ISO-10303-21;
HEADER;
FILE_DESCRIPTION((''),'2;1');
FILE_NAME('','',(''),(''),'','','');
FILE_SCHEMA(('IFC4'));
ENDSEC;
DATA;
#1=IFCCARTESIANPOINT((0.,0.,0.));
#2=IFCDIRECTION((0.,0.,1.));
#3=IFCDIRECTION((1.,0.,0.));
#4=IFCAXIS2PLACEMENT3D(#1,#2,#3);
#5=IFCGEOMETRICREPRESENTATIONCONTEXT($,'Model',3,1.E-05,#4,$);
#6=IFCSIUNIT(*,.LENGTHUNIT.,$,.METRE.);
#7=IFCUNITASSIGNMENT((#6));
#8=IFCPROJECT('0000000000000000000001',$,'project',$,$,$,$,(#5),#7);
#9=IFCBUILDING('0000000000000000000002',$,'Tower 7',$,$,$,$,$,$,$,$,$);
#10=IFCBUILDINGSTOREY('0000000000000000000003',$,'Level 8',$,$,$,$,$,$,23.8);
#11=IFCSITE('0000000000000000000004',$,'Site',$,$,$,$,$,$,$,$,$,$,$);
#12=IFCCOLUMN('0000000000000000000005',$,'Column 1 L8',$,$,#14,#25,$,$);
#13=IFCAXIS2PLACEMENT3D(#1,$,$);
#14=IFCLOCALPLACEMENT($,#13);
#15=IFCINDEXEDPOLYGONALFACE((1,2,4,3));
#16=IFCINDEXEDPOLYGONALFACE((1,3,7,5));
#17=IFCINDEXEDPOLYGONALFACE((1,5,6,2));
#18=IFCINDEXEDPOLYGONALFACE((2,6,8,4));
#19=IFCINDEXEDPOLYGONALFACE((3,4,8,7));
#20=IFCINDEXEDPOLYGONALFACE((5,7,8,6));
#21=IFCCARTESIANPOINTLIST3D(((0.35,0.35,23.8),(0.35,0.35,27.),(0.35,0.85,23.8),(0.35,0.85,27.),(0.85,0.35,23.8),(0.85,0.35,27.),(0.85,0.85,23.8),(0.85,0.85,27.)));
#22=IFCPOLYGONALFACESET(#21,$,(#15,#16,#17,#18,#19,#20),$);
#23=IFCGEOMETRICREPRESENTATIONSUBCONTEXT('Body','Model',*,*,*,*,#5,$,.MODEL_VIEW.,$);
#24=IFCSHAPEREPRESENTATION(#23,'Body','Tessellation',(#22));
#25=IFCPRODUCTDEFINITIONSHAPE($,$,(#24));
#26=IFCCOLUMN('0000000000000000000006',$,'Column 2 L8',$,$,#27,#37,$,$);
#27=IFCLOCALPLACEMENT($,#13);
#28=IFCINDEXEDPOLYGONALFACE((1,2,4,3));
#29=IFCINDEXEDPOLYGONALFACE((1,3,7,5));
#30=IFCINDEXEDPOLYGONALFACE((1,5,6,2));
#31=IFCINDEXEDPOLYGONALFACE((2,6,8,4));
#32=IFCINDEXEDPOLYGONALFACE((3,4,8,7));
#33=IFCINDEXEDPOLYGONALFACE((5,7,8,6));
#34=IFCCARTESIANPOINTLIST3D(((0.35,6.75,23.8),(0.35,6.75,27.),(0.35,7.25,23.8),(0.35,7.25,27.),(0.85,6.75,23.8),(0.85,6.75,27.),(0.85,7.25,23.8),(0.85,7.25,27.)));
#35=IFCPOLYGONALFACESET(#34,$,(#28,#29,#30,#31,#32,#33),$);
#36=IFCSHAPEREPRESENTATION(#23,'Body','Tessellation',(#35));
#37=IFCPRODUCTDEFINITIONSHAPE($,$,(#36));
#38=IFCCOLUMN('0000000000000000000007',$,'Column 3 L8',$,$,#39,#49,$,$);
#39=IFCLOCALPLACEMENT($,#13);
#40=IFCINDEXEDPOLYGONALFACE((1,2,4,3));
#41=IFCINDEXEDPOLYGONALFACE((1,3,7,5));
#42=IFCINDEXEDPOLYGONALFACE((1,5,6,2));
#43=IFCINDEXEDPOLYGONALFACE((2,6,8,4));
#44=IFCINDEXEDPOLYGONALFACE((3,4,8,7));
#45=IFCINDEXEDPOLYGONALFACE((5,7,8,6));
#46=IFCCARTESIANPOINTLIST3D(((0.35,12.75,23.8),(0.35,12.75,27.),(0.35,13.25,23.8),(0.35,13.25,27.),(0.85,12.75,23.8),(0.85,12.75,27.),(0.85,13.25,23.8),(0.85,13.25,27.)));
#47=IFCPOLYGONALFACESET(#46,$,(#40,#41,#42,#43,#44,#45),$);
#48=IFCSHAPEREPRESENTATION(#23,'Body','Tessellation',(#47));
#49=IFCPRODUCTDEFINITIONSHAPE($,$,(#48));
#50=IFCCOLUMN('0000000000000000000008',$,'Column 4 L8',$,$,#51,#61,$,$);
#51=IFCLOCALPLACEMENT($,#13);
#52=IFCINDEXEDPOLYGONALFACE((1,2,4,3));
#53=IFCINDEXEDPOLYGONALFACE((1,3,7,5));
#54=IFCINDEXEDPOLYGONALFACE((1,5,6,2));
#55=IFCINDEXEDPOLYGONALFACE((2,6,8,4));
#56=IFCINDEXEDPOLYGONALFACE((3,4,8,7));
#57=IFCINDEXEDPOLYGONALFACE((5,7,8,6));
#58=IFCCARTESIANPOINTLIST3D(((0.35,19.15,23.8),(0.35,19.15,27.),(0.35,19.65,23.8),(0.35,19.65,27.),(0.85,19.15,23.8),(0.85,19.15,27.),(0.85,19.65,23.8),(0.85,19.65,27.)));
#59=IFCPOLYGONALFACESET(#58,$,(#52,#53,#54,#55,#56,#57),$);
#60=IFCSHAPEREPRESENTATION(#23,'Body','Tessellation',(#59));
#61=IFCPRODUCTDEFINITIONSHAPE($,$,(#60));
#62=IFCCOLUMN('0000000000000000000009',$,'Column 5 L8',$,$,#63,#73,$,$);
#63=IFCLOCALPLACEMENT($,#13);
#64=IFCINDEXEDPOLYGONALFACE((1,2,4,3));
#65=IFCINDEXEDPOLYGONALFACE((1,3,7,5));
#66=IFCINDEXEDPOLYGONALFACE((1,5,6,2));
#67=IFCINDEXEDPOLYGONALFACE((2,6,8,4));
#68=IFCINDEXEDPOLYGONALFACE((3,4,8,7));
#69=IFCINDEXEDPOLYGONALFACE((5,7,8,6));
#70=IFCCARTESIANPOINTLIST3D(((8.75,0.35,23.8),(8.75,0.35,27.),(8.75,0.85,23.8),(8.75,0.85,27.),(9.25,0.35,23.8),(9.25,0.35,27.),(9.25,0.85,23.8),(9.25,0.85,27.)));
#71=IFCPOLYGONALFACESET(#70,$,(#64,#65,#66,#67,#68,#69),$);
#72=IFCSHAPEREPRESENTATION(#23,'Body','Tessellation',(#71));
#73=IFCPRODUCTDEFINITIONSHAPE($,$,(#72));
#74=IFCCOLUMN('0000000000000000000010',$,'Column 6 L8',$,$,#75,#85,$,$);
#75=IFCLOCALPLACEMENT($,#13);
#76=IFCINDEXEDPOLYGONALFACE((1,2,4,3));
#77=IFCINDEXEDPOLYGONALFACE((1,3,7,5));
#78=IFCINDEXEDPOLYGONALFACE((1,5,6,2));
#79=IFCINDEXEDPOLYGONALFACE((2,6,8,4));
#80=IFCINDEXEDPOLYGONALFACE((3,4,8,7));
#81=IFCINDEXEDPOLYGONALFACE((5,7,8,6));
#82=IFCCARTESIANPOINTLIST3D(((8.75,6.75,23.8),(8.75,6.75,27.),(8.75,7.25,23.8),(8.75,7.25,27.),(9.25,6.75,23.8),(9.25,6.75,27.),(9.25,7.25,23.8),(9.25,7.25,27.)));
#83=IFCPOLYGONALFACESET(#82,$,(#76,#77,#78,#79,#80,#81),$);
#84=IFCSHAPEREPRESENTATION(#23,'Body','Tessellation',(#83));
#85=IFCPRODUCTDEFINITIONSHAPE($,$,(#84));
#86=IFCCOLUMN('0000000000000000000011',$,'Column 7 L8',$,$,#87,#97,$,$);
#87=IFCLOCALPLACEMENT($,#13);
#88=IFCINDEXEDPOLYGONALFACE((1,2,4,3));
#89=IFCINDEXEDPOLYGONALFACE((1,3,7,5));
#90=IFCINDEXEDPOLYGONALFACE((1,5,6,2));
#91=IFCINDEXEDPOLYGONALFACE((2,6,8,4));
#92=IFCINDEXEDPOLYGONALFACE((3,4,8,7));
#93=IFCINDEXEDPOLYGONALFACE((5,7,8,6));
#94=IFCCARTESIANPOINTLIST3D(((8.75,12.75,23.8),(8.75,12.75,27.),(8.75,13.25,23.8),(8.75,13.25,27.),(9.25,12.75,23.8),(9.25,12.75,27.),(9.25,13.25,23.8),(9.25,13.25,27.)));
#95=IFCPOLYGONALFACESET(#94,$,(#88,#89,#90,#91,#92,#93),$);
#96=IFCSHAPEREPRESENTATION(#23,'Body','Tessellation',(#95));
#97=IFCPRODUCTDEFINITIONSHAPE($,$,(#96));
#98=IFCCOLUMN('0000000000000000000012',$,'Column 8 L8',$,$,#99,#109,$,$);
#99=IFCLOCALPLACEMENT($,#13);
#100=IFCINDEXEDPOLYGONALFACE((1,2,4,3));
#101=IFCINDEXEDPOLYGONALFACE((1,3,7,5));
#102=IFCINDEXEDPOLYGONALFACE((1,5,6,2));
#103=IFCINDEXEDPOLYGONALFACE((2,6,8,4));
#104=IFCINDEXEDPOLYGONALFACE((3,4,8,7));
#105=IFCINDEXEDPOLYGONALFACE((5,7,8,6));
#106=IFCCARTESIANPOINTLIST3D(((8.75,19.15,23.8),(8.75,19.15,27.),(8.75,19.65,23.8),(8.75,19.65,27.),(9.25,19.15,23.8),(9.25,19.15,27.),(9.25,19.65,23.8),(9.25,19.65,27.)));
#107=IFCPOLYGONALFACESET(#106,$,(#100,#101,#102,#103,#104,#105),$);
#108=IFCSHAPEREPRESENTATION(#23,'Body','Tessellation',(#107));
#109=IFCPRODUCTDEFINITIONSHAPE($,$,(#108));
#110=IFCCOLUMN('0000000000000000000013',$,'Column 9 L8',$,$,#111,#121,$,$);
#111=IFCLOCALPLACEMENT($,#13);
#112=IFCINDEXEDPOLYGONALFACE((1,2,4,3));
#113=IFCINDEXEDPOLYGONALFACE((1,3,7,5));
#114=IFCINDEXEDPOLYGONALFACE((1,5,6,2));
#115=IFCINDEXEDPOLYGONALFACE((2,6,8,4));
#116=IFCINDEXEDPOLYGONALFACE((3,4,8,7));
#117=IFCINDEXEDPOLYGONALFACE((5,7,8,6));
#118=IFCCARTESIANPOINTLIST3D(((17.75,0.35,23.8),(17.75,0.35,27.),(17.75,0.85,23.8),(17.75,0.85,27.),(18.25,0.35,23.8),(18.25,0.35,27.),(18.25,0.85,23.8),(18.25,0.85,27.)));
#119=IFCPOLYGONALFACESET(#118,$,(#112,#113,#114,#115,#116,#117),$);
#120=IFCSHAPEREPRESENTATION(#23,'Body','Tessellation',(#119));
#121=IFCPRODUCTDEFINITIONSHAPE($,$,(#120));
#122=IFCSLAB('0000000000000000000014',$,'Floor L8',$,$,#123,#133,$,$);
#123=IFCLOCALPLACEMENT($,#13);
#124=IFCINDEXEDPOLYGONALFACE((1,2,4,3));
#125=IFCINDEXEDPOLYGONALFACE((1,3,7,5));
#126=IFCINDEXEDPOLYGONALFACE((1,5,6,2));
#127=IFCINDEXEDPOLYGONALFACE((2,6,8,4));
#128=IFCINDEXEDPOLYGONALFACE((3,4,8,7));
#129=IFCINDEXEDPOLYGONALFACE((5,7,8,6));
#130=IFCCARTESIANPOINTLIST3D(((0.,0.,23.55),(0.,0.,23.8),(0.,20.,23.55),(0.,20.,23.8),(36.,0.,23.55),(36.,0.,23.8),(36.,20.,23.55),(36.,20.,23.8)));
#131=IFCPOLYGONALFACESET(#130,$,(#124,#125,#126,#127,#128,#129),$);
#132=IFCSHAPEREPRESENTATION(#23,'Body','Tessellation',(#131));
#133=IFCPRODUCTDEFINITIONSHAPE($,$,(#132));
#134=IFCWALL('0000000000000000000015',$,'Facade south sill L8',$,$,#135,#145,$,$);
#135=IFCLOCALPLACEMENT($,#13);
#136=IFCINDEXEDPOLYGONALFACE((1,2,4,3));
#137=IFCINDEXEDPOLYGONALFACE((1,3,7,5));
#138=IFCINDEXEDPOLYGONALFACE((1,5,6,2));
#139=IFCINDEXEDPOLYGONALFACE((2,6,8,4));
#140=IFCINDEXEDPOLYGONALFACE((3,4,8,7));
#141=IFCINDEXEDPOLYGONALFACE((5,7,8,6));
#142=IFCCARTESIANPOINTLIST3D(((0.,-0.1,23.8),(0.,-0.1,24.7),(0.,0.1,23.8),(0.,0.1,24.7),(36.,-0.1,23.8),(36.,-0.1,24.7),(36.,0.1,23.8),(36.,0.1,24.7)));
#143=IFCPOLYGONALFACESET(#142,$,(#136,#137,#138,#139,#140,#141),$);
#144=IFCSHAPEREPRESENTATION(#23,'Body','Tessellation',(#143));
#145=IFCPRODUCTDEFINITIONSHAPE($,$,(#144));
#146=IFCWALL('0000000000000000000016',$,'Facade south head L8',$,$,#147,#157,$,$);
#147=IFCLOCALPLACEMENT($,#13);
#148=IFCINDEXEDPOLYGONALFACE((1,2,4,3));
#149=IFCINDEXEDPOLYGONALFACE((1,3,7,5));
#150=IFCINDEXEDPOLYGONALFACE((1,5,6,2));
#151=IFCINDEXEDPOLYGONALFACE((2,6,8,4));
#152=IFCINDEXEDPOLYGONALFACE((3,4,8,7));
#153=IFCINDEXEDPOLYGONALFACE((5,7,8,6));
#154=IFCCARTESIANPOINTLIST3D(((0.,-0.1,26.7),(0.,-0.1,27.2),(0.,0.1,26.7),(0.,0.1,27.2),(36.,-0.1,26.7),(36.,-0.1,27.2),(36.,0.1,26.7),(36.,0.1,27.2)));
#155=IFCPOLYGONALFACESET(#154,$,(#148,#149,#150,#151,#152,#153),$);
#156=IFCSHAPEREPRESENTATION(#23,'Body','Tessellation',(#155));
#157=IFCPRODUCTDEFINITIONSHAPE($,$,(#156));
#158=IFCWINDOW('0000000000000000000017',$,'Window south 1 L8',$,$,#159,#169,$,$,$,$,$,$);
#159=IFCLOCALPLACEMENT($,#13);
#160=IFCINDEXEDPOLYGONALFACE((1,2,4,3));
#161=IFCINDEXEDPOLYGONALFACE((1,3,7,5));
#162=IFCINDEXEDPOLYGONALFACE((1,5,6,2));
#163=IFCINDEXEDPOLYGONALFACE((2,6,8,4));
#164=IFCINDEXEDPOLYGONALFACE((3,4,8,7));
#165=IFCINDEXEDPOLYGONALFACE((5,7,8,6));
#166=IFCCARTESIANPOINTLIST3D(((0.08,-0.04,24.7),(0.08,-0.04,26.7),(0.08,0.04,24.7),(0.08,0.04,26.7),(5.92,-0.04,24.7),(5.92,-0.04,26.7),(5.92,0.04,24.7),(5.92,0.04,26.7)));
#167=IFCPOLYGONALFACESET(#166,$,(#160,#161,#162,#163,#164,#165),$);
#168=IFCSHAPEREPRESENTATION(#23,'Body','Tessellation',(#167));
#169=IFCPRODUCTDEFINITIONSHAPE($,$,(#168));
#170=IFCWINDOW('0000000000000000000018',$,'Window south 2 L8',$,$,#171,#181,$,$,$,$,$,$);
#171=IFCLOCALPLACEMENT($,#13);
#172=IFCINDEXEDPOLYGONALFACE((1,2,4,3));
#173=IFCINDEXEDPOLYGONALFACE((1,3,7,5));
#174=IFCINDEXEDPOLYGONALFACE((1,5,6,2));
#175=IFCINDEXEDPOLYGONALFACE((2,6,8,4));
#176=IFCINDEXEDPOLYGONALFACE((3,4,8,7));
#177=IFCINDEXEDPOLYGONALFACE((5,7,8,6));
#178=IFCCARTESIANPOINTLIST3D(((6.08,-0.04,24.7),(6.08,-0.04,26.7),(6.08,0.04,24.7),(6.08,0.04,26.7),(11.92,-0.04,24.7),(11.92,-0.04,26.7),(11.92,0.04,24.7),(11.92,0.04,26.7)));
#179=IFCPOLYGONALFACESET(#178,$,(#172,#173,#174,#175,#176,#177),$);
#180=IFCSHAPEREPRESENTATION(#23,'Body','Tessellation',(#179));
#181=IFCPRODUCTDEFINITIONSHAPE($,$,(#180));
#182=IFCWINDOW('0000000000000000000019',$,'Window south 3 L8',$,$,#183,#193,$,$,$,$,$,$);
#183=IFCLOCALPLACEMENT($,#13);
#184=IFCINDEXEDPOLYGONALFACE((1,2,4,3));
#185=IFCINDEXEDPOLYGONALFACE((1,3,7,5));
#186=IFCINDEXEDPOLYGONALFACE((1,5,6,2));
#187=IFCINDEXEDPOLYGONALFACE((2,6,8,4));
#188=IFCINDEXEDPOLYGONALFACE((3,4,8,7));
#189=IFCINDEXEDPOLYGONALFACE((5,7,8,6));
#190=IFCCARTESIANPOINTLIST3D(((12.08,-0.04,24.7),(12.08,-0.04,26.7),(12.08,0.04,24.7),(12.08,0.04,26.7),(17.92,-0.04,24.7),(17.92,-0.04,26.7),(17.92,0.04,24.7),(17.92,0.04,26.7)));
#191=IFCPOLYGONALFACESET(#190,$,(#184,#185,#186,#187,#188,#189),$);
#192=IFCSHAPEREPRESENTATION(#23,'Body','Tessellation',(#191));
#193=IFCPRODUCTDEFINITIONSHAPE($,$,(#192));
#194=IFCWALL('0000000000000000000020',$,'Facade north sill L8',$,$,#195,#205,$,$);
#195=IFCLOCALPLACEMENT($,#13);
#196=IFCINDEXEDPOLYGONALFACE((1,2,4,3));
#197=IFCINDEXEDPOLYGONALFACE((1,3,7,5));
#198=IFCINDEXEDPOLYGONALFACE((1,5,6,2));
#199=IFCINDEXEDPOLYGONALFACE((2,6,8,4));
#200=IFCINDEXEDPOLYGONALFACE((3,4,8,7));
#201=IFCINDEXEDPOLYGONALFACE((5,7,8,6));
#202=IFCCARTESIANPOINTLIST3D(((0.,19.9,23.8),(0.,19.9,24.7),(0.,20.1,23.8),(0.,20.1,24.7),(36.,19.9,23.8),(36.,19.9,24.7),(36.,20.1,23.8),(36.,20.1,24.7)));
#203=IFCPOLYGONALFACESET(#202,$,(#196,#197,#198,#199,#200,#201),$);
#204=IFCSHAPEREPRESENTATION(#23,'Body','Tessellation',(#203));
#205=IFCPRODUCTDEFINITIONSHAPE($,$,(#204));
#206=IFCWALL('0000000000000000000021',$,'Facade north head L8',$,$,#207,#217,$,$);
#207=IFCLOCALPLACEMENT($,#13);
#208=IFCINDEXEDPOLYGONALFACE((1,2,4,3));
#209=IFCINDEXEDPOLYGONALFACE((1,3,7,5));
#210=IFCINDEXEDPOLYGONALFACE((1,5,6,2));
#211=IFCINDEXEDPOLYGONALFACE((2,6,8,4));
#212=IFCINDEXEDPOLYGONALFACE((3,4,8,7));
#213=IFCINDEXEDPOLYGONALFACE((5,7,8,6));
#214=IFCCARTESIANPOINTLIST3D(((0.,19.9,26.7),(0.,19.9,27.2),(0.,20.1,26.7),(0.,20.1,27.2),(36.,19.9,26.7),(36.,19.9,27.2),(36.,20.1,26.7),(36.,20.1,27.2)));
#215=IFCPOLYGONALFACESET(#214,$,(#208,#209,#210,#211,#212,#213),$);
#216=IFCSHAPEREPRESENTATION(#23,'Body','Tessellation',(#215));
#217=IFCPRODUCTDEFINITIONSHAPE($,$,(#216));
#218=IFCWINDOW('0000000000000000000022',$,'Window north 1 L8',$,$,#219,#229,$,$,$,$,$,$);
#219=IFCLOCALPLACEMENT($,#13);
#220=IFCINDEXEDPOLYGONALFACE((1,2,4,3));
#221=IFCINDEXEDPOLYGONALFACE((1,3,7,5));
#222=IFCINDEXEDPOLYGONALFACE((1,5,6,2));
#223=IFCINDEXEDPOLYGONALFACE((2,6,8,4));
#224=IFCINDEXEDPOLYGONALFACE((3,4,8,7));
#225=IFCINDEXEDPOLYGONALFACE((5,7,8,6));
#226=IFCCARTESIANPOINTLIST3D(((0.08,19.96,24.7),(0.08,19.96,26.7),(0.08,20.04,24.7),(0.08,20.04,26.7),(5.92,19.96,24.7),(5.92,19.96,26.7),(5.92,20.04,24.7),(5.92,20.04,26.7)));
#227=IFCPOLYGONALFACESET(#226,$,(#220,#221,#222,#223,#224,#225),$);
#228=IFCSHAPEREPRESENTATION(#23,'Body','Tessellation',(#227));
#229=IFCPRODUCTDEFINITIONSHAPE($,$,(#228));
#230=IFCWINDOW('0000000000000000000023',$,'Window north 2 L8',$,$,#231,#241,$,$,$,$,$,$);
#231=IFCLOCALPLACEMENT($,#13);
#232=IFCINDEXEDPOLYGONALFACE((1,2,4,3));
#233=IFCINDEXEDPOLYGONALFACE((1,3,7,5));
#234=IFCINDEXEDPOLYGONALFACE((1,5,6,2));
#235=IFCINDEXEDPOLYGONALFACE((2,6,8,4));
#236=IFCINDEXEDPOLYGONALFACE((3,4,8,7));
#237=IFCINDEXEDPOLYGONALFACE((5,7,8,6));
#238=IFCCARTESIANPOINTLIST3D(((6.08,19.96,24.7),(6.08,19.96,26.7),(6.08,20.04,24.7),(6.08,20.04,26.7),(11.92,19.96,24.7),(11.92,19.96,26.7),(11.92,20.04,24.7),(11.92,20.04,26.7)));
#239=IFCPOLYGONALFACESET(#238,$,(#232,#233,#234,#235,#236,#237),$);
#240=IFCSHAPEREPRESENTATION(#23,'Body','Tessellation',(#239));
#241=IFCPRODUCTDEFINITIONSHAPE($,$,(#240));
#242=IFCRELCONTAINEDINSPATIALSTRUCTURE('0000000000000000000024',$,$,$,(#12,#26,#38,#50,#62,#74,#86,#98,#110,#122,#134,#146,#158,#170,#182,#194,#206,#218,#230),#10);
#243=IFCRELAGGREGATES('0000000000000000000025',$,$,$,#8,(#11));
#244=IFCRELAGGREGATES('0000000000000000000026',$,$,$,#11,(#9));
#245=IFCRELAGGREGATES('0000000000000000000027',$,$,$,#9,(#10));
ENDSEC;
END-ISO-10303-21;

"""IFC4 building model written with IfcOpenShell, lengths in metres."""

from ifc_helpers import new_model, si_unit, frame, origin, origin_with_axes, origin_2d, place, context, subcontext, project, spatial, rectangle, extrude, element, save


model = new_model("IFC4")

# Units and contexts
model_context = context("Model", 3, precision=1e-05, world=origin_with_axes())
body_context = subcontext(model_context, "Body", "Model", "MODEL_VIEW")
ifc_project = project(units=[si_unit("LENGTHUNIT", "METRE")], contexts=[model_context])

# Site, building, storey
site = spatial("IfcSite", under=ifc_project, Name="Site")
building = spatial("IfcBuilding", under=site, Name="Tower 7")
storey = spatial("IfcBuildingStorey", under=building, Name="Level 8", Elevation=23.8)

# Columns
for number, where, z_axis, x_axis, name in (
    (1, (0.6, 0.6, 23.8), (0.0, 0.0, 1.0), (1.0, 0.0, 0.0), "Column 1 L8"),
    (2, (0.6, 7.0, 23.8), (0.0, 0.0, 1.0), (1.0, 0.0, 0.0), "Column 2 L8"),
    (3, (0.6, 13.0, 23.8), (0.0, 0.0, 1.0), (1.0, 0.0, 0.0), "Column 3 L8"),
    (4, (0.6, 19.4, 23.8), (0.0, 0.0, 1.0), (1.0, 0.0, 0.0), "Column 4 L8"),
    (5, (9.0, 0.6, 23.8), (0.0, 0.0, 1.0), (1.0, 0.0, 0.0), "Column 5 L8"),
    (6, (9.0, 7.0, 23.8), (0.0, 0.0, 1.0), (1.0, 0.0, 0.0), "Column 6 L8"),
    (7, (9.0, 13.0, 23.8), (0.0, 0.0, 1.0), (1.0, 0.0, 0.0), "Column 7 L8"),
    (8, (9.0, 19.4, 23.8), (0.0, 0.0, 1.0), (1.0, 0.0, 0.0), "Column 8 L8"),
    (9, (18.0, 0.6, 23.8), (0.0, 0.0, 1.0), (1.0, 0.0, 0.0), "Column 9 L8"),
):
    element("IfcColumn", number, at=place(None, frame(where, z_axis=z_axis, x_axis=x_axis)), inside=storey, Name=name, context=body_context, shape_type="SweptSolid", body=[
        extrude(rectangle(XDim=0.5, YDim=0.5, at=origin_2d()), origin(), (0.0, 0.0, 1.0), 3.2),
    ])

# Slab
slab_placement = place(None, frame((18.0, 10.0, 23.55), z_axis=(0.0, 0.0, 1.0), x_axis=(1.0, 0.0, 0.0)))
element("IfcSlab", 10, at=slab_placement, inside=storey, Name="Floor L8", context=body_context, shape_type="SweptSolid", body=[
    extrude(rectangle(XDim=36.0, YDim=20.0, at=origin_2d()), origin(), (0.0, 0.0, 1.0), 0.25),
])

# Walls
wall_1_placement = place(None, frame((18.0, 0.0, 23.8), z_axis=(0.0, 0.0, 1.0), x_axis=(1.0, 0.0, 0.0)))
element("IfcWall", 11, at=wall_1_placement, inside=storey, Name="Facade south sill L8", context=body_context, shape_type="SweptSolid", body=[
    extrude(rectangle(XDim=36.0, YDim=0.2, at=origin_2d()), origin(), (0.0, 0.0, 1.0), 0.9),
])
wall_2_placement = place(None, frame((18.0, 0.0, 26.7), z_axis=(0.0, 0.0, 1.0), x_axis=(1.0, 0.0, 0.0)))
element("IfcWall", 12, at=wall_2_placement, inside=storey, Name="Facade south head L8", context=body_context, shape_type="SweptSolid", body=[
    extrude(rectangle(XDim=36.0, YDim=0.2, at=origin_2d()), origin(), (0.0, 0.0, 1.0), 0.5),
])

# Windows
for number, where, z_axis, x_axis, name in (
    (13, (3.0, 0.0, 24.7), (0.0, 0.0, 1.0), (1.0, 0.0, 0.0), "Window south 1 L8"),
    (14, (9.0, 0.0, 24.7), (0.0, 0.0, 1.0), (1.0, 0.0, 0.0), "Window south 2 L8"),
):
    element("IfcWindow", number, at=place(None, frame(where, z_axis=z_axis, x_axis=x_axis)), inside=storey, Name=name, context=body_context, shape_type="SweptSolid", body=[
        extrude(rectangle(XDim=5.84, YDim=0.08, at=origin_2d()), origin(), (0.0, 0.0, 1.0), 2.0),
    ])
window_1_placement = place(None, frame((15.0, 0.0, 24.7), z_axis=(0.0, 0.0, 1.0), x_axis=(1.0, 0.0, 0.0)))
element("IfcWindow", 15, at=window_1_placement, inside=storey, Name="Window south 3 L8", context=body_context, shape_type="SweptSolid", body=[
    extrude(rectangle(XDim=5.84, YDim=0.08, at=origin_2d()), origin(), (0.0, 0.0, 1.0), 2.0),
])

# Walls
wall_3_placement = place(None, frame((18.0, 20.0, 23.8), z_axis=(0.0, 0.0, 1.0), x_axis=(1.0, 0.0, 0.0)))
element("IfcWall", 16, at=wall_3_placement, inside=storey, Name="Facade north sill L8", context=body_context, shape_type="SweptSolid", body=[
    extrude(rectangle(XDim=36.0, YDim=0.2, at=origin_2d()), origin(), (0.0, 0.0, 1.0), 0.9),
])
wall_4_placement = place(None, frame((18.0, 20.0, 26.7), z_axis=(0.0, 0.0, 1.0), x_axis=(1.0, 0.0, 0.0)))
element("IfcWall", 17, at=wall_4_placement, inside=storey, Name="Facade north head L8", context=body_context, shape_type="SweptSolid", body=[
    extrude(rectangle(XDim=36.0, YDim=0.2, at=origin_2d()), origin(), (0.0, 0.0, 1.0), 0.5),
])

# Windows
for number, where, z_axis, x_axis, name in (
    (18, (3.0, 20.0, 24.7), (0.0, 0.0, 1.0), (1.0, 0.0, 0.0), "Window north 1 L8"),
    (19, (9.0, 20.0, 24.7), (0.0, 0.0, 1.0), (1.0, 0.0, 0.0), "Window north 2 L8"),
):
    element("IfcWindow", number, at=place(None, frame(where, z_axis=z_axis, x_axis=x_axis)), inside=storey, Name=name, context=body_context, shape_type="SweptSolid", body=[
        extrude(rectangle(XDim=5.84, YDim=0.08, at=origin_2d()), origin(), (0.0, 0.0, 1.0), 2.0),
    ])

save(model, "model.ifc")
